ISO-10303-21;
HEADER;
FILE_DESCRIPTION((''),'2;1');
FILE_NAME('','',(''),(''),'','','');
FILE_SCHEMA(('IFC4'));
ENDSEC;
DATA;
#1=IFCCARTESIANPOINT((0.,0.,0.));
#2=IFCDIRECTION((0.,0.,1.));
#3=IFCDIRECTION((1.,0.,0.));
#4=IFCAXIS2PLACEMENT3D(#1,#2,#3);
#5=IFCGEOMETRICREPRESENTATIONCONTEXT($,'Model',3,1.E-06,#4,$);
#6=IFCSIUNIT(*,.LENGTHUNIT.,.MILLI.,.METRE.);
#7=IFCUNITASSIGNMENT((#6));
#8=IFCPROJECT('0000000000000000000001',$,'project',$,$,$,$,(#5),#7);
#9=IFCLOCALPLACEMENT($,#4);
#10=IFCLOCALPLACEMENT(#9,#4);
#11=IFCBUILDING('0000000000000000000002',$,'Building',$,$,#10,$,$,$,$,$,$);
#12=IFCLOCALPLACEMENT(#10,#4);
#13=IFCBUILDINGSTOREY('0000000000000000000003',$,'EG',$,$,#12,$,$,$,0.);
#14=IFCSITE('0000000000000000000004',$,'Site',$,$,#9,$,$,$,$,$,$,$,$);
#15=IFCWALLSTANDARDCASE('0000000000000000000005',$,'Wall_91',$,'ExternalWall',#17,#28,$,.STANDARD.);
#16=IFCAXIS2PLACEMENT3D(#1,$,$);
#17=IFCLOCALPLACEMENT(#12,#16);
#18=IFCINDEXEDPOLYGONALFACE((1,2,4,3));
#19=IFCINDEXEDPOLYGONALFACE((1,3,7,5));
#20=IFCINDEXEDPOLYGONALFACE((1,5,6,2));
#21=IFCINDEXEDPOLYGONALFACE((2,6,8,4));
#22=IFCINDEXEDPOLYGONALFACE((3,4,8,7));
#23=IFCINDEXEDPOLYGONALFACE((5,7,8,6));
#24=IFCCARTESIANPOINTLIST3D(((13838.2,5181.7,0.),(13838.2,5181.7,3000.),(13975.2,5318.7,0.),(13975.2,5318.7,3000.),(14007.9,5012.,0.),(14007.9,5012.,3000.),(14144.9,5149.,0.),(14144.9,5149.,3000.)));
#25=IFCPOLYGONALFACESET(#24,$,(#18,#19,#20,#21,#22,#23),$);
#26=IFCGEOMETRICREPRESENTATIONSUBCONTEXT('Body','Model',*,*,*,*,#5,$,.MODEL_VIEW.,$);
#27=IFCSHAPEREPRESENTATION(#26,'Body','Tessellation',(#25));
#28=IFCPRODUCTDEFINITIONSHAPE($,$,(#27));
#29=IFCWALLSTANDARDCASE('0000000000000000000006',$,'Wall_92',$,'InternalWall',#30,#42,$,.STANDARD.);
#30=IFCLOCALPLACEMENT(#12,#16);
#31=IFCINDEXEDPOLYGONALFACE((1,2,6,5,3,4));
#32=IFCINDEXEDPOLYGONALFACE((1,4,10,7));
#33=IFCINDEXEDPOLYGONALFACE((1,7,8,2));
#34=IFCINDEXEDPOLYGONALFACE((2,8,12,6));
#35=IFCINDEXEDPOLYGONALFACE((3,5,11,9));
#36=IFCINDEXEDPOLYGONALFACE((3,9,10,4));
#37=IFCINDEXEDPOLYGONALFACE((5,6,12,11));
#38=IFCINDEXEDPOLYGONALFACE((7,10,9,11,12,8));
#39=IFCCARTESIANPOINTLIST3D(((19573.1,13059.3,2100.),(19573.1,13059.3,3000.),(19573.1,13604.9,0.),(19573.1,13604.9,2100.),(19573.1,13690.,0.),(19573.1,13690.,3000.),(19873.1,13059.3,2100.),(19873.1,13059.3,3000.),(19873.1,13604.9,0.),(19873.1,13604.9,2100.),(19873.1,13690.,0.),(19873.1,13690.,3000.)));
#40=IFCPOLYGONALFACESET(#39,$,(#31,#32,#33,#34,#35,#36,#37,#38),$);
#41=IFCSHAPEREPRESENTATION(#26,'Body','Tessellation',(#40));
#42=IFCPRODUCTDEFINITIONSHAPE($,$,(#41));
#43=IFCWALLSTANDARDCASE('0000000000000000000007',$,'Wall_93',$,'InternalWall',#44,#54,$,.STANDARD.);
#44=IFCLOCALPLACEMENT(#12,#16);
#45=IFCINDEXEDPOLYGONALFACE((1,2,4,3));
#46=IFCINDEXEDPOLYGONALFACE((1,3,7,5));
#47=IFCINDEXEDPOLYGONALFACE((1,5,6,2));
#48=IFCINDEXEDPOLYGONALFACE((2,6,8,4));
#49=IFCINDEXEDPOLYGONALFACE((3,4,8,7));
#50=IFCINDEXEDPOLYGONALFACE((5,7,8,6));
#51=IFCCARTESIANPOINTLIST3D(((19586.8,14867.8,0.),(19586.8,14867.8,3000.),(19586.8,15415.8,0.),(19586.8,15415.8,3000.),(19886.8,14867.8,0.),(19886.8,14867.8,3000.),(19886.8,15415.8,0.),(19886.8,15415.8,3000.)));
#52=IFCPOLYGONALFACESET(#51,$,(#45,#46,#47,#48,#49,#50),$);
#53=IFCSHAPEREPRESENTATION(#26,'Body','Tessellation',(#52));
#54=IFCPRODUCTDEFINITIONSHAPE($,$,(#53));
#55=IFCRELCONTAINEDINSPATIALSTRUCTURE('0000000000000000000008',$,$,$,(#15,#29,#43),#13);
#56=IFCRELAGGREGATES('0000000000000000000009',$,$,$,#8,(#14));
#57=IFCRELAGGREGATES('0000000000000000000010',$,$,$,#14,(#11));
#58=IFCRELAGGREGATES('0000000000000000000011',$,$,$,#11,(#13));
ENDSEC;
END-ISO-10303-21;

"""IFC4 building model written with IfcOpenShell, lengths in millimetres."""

from ifc_helpers import new_model, si_unit, frame, origin_with_axes, place, context, subcontext, project, spatial, rectangle, extrude, element, save


model = new_model("IFC4")

# Units and contexts
model_context = context("Model", 3, precision=1e-06, world=origin_with_axes())
body_context = subcontext(model_context, "Body", "Model", "MODEL_VIEW")
ifc_project = project(units=[si_unit("LENGTHUNIT", "METRE", prefix="MILLI")], contexts=[model_context])

# Site, building, storey
site_placement = place(None, origin_with_axes())
site = spatial("IfcSite", under=ifc_project, at=site_placement, Name="Site")
building_placement = place(site_placement, origin_with_axes())
building = spatial("IfcBuilding", under=site, at=building_placement, Name="Building")
storey_placement = place(building_placement, origin_with_axes())
storey = spatial("IfcBuildingStorey", under=building, at=storey_placement, Name="EG", Elevation=0.0)

# Wall
wall_1_placement = place(storey_placement, origin_with_axes())
element("IfcWallStandardCase", 1, at=wall_1_placement, inside=storey, Name="Wall_91", ObjectType="ExternalWall", PredefinedType="STANDARD", context=body_context, shape_type="SweptSolid", body=[
    extrude(rectangle(XDim=193.7, YDim=240.0), frame((13991.5, 5165.3, 0.0), z_axis=(0.0, 0.0, 1.0), x_axis=(-0.707107, -0.707107, 0.0)), (0.0, 0.0, 1.0), 3000.0),
])

# Wall, opening
wall_2_placement = place(storey_placement, origin_with_axes())
wall_2 = element("IfcWallStandardCase", 2, at=wall_2_placement, inside=storey, Name="Wall_92", ObjectType="InternalWall", PredefinedType="STANDARD", context=body_context, shape_type="SweptSolid", body=[
    extrude(rectangle(XDim=630.7, YDim=300.0), frame((19723.1, 13374.7, 0.0), z_axis=(0.0, 0.0, 1.0), x_axis=(0.0, -1.0, 0.0)), (0.0, 0.0, 1.0), 3000.0),
])
opening_1_placement = place(wall_2_placement, origin_with_axes())
element("IfcOpeningElement", 3, at=opening_1_placement, inside=storey, cuts=wall_2, context=body_context, shape_type="SweptSolid", body=[
    extrude(rectangle(XDim=914.0, YDim=300.0), frame((19723.1, 13147.9, 0.0), z_axis=(0.0, 0.0, 1.0), x_axis=(0.0, -1.0, 0.0)), (0.0, 0.0, 1.0), 2100.0),
])

# Wall
wall_3_placement = place(storey_placement, origin_with_axes())
element("IfcWallStandardCase", 4, at=wall_3_placement, inside=storey, Name="Wall_93", ObjectType="InternalWall", PredefinedType="STANDARD", context=body_context, shape_type="SweptSolid", body=[
    extrude(rectangle(XDim=547.9, YDim=300.0), frame((19736.8, 15141.8, 0.0), z_axis=(0.0, 0.0, 1.0), x_axis=(0.0, 1.0, 0.0)), (0.0, 0.0, 1.0), 3000.0),
])

save(model, "model.ifc")
